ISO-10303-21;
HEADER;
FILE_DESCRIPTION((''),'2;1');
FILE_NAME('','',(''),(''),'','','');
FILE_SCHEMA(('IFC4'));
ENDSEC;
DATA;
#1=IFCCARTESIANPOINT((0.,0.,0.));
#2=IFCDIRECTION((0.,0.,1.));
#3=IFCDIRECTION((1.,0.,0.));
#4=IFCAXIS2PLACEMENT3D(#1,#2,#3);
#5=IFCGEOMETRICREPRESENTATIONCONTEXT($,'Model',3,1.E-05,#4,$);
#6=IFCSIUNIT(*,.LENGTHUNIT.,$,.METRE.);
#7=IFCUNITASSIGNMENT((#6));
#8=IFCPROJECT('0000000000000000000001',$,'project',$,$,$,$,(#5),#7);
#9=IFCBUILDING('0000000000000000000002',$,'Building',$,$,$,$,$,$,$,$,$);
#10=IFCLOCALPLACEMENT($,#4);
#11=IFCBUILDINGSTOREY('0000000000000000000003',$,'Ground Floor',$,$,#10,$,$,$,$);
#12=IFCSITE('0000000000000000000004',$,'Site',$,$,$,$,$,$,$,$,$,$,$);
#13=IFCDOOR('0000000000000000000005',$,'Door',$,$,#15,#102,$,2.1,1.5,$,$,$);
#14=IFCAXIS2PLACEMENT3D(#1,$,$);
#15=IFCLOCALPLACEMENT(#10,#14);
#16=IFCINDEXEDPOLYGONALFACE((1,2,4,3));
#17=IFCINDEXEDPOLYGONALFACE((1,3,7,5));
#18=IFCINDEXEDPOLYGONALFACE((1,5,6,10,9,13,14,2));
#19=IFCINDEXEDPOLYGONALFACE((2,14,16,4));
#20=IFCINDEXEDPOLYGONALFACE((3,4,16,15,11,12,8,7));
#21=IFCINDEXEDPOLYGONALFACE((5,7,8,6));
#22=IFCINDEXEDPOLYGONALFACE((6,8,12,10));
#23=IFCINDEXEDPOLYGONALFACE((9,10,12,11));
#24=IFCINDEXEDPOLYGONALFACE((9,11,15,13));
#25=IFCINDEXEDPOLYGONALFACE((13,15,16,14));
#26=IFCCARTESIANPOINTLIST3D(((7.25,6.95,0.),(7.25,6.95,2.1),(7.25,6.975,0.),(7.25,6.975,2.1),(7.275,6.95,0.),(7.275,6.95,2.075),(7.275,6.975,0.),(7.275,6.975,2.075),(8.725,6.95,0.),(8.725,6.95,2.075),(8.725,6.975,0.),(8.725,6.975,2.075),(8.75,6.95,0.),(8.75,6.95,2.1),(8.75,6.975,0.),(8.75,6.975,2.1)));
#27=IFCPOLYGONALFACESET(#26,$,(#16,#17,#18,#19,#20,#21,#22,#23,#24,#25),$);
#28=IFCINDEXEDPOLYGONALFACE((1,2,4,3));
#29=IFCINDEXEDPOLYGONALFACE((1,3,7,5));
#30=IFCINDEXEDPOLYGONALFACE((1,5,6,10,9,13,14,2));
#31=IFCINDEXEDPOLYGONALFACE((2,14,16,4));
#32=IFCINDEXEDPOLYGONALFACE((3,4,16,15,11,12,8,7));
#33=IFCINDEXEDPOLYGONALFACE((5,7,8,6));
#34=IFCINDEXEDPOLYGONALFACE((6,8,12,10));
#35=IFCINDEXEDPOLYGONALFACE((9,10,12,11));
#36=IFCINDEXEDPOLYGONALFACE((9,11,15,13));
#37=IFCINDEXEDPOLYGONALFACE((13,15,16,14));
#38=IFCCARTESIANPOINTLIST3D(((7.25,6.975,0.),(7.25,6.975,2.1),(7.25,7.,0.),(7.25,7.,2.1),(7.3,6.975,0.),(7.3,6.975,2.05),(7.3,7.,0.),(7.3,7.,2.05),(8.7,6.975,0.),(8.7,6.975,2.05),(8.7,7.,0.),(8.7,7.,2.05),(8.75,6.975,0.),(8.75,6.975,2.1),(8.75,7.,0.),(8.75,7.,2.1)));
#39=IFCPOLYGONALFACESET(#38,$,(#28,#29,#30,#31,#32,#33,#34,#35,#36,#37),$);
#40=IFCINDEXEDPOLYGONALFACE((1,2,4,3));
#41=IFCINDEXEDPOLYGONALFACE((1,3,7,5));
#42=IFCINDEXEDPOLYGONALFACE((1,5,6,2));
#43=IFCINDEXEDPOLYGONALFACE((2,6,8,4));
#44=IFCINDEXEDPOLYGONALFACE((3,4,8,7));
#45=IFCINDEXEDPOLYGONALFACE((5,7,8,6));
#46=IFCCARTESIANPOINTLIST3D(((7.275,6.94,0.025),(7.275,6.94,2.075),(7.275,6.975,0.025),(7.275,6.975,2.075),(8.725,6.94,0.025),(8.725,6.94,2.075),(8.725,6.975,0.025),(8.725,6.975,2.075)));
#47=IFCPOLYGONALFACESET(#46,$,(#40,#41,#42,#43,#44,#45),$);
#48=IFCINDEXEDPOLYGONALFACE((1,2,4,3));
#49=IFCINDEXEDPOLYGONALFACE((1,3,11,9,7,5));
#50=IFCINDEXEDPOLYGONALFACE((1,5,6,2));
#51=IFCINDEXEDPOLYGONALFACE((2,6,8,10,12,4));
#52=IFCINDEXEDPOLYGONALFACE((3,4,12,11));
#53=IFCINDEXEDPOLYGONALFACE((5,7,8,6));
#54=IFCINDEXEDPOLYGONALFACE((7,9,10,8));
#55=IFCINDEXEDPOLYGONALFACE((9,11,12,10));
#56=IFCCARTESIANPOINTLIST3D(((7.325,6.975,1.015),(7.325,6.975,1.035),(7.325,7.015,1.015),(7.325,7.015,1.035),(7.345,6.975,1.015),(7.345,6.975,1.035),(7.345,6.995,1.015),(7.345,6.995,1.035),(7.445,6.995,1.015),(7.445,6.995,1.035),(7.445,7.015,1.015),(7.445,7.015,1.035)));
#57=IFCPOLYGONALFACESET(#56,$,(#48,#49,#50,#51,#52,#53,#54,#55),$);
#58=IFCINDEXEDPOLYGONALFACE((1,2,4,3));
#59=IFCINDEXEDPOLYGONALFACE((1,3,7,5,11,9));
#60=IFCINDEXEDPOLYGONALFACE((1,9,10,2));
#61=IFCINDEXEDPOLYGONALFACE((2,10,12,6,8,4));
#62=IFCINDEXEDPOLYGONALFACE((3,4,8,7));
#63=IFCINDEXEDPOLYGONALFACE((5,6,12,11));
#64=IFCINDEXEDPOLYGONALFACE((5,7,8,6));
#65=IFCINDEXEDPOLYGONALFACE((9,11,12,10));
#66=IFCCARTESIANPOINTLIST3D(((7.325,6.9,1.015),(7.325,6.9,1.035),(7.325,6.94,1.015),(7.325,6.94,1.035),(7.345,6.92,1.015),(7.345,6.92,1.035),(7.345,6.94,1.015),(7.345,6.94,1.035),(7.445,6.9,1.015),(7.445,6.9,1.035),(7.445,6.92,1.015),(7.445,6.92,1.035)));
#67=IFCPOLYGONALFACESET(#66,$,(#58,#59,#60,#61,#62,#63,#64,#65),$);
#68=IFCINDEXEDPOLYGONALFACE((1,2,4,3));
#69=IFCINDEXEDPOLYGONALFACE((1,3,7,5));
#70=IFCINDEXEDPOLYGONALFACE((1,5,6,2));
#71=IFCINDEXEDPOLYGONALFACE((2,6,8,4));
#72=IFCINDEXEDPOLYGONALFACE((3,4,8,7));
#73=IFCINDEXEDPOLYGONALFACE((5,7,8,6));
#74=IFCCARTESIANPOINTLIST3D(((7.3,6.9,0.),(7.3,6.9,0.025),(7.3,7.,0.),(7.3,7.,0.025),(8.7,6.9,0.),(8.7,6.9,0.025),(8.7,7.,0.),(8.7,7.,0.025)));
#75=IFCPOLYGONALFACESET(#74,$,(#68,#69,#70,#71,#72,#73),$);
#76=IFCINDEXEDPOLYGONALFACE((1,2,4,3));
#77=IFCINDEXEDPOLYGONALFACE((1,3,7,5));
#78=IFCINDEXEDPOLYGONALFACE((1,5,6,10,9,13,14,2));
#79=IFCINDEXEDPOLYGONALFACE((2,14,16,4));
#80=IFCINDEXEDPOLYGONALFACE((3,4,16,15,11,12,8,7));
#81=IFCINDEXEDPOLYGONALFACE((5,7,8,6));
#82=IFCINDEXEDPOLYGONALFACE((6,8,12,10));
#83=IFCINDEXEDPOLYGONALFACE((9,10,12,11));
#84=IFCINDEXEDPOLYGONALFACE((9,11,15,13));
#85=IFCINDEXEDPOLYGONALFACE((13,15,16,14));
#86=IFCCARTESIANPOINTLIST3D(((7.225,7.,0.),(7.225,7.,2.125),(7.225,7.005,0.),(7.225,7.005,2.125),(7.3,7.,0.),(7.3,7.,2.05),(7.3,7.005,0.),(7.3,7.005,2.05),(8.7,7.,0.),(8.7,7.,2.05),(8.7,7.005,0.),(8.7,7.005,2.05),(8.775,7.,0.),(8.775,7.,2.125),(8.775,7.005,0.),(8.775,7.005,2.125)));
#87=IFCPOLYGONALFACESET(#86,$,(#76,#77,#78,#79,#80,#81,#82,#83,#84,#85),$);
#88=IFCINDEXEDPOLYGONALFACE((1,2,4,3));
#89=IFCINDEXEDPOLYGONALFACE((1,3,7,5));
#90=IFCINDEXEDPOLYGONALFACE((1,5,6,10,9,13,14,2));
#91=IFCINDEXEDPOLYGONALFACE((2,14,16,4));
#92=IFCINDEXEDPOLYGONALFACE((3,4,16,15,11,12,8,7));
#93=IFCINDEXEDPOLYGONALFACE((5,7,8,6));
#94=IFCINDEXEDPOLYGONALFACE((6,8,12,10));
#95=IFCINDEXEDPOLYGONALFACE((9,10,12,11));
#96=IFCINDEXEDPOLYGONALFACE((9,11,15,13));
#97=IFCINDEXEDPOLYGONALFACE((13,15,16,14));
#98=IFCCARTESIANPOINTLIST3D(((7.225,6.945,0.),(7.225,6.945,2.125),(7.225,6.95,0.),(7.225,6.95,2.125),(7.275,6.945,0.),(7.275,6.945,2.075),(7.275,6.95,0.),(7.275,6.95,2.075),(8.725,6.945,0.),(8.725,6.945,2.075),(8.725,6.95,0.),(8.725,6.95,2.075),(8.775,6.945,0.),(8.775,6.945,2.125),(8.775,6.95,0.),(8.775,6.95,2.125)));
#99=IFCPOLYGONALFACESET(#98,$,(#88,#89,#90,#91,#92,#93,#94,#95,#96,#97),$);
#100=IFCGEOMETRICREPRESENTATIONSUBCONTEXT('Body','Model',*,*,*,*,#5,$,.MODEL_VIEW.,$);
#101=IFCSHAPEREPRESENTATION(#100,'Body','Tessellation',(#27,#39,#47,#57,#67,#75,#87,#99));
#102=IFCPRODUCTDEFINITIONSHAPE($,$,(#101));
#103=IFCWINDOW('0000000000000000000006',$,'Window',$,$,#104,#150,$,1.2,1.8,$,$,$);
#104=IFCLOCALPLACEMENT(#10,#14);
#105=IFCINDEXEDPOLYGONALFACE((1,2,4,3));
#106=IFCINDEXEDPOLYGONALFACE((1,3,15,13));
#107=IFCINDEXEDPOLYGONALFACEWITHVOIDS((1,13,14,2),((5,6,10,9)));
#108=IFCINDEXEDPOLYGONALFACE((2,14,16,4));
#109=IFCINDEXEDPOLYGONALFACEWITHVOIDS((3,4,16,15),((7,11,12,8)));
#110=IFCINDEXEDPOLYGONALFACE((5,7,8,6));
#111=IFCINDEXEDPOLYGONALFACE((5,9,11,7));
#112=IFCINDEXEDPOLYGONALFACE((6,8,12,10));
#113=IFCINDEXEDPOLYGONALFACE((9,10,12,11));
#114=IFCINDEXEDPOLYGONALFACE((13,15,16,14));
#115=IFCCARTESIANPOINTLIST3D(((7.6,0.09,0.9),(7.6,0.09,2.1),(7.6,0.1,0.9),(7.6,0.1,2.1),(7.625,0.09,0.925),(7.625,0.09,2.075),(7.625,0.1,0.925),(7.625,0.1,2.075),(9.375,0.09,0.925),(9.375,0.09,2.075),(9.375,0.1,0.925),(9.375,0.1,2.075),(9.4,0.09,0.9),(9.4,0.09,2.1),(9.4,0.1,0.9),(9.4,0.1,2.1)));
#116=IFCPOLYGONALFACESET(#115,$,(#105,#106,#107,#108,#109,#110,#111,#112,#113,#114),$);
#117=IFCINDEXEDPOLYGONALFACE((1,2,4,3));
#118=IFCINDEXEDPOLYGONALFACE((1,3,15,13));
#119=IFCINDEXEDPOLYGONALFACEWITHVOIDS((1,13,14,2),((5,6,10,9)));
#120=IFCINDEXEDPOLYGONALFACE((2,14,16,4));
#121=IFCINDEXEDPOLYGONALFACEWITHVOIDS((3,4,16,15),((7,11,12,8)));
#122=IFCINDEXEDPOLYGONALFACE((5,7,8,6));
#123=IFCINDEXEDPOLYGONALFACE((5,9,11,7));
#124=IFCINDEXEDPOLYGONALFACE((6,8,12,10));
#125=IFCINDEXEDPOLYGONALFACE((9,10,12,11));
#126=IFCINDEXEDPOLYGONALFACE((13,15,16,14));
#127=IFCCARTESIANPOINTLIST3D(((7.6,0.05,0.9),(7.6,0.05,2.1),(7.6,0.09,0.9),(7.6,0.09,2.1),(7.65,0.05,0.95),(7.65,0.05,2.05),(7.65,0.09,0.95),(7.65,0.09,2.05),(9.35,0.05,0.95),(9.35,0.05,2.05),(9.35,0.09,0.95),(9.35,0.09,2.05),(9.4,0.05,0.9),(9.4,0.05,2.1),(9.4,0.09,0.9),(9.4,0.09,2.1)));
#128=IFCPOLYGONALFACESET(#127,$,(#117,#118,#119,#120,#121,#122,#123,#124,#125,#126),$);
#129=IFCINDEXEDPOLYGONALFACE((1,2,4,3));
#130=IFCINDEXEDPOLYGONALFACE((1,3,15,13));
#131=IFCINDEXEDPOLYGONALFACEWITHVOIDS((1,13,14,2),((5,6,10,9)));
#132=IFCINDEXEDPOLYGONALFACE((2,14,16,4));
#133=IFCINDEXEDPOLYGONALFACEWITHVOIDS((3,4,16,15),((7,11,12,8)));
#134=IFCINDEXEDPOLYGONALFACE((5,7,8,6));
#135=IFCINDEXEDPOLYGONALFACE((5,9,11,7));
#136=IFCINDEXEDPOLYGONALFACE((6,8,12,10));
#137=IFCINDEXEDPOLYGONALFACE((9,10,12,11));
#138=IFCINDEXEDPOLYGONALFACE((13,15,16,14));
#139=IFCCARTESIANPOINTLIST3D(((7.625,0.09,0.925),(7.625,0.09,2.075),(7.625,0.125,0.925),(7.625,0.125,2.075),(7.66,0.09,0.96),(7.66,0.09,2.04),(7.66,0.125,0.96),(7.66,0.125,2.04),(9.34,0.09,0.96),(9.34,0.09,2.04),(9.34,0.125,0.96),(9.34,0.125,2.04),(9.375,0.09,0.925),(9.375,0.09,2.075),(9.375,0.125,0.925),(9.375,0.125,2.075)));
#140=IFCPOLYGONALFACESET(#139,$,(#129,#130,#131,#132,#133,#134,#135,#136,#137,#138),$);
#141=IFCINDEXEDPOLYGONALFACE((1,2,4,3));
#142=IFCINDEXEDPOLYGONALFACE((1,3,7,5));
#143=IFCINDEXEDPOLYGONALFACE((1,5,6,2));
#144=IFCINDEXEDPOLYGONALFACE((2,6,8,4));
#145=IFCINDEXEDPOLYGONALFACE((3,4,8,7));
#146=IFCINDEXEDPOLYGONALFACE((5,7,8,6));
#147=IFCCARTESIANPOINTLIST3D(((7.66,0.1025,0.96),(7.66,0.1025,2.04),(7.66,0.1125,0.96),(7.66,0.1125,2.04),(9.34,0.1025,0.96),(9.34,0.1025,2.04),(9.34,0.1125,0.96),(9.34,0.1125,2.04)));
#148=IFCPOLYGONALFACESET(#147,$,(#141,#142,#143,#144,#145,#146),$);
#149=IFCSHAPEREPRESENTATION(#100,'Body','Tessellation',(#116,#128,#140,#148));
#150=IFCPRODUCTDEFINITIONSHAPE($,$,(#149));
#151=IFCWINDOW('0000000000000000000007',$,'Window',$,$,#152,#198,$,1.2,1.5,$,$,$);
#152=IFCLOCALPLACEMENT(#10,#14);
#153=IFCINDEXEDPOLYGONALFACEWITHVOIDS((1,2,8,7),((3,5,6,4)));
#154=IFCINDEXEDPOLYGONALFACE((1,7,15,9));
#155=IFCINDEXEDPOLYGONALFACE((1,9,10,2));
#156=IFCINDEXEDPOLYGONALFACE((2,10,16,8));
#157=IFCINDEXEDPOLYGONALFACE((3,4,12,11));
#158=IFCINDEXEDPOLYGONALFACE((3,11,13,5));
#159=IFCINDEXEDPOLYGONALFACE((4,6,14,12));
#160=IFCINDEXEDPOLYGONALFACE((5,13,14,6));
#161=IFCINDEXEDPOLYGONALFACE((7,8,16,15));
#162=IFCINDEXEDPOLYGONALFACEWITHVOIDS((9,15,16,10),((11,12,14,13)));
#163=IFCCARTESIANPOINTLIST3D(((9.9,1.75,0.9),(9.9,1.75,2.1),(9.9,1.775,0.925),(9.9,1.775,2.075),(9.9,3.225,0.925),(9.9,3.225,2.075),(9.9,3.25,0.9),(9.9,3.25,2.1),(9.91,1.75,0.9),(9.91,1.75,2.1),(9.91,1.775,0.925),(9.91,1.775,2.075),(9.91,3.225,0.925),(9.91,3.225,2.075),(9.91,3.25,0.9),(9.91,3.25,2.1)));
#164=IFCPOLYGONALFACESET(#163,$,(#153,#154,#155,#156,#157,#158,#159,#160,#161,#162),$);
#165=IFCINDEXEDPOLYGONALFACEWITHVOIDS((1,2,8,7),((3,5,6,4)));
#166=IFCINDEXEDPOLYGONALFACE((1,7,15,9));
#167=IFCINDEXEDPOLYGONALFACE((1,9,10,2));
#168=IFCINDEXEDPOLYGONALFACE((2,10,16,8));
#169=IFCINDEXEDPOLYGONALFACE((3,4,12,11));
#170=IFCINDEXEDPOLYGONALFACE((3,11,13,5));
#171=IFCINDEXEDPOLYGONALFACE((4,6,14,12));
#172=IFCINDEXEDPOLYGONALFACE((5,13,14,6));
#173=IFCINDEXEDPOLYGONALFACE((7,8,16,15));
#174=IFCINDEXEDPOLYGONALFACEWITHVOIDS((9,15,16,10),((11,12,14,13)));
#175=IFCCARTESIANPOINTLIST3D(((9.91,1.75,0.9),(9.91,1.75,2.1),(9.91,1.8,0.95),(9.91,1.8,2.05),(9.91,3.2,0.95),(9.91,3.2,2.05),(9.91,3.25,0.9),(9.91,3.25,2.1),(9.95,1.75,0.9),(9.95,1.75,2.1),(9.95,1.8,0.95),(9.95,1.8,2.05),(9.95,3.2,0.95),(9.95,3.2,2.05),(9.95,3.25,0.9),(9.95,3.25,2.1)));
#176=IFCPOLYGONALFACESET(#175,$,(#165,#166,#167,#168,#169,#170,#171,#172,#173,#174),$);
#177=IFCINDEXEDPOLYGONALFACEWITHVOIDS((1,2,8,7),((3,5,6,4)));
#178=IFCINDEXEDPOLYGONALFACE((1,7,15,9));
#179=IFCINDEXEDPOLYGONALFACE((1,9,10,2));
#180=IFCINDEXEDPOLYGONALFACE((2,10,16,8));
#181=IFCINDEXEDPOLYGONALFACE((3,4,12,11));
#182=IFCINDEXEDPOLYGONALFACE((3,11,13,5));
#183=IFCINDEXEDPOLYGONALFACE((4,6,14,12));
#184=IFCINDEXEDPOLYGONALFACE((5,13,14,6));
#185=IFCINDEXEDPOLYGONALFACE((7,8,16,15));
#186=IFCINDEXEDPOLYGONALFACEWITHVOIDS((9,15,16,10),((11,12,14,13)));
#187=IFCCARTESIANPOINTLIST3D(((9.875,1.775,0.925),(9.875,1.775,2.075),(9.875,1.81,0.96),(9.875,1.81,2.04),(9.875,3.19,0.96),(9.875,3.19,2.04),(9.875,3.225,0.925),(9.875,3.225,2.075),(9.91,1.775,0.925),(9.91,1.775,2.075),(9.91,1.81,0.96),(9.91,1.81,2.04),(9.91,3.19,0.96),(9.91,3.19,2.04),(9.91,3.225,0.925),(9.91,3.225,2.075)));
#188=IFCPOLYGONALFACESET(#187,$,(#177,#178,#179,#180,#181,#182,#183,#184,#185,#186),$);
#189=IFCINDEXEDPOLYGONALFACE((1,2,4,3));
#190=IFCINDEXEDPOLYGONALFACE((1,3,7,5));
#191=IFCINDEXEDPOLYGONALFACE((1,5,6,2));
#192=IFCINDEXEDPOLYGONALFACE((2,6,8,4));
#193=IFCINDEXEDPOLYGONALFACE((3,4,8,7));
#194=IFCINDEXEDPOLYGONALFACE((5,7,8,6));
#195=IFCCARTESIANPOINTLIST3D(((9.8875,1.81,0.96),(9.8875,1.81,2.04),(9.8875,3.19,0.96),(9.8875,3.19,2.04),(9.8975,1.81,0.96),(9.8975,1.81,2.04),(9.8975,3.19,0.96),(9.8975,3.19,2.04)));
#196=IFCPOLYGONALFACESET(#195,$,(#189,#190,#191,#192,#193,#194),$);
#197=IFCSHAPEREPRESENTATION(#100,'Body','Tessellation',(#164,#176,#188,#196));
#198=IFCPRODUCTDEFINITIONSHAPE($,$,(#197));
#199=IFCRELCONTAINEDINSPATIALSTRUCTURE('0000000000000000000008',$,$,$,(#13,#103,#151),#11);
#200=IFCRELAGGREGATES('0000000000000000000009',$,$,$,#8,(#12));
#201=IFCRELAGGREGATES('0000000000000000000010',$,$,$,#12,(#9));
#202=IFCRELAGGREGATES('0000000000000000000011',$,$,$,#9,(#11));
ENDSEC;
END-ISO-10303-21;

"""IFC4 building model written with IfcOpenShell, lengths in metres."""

from ifc_helpers import new_model, si_unit, frame, origin_with_axes, place, context, subcontext, project, spatial, line, indexed_curve, outline, extrude, element, save


model = new_model("IFC4")

# Units and contexts
model_context = context("Model", 3, precision=1e-05, world=origin_with_axes())
body_context = subcontext(model_context, "Body", "Model", "MODEL_VIEW")
ifc_project = project(units=[si_unit("LENGTHUNIT", "METRE")], contexts=[model_context])

# Site, building, storey
site = spatial("IfcSite", under=ifc_project, Name="Site")
building = spatial("IfcBuilding", under=site, Name="Building")
storey_placement = place(None, origin_with_axes())
storey = spatial("IfcBuildingStorey", under=building, at=storey_placement, Name="Ground Floor")

# Door
door_1_placement = place(storey_placement, frame((8.75, 7.0, 0.0), z_axis=(0.0, 0.0, 1.0), x_axis=(-1.0, 0.0, 0.0)))
element("IfcDoor", 1, at=door_1_placement, inside=storey, Name="Door", OverallHeight=2.1, OverallWidth=1.5, context=body_context, shape_type="SweptSolid", body=[
    extrude(outline(indexed_curve([(0.0, 0.0), (0.0, 2.1), (1.5, 2.1), (1.5, 0.0), (1.475, 0.0), (1.475, 2.075), (0.025, 2.075), (0.025, 0.0)], segments=[line(1, 2, 3, 4, 5, 6, 7, 8, 1)])), frame((0.0, 0.025, 0.0), z_axis=(0.0, -1.0, 0.0), x_axis=(1.0, 0.0, 0.0)), (0.0, 0.0, -1.0), 0.025),
    extrude(outline(indexed_curve([(0.0, 0.0), (0.0, 2.1), (1.5, 2.1), (1.5, 0.0), (1.45, 0.0), (1.45, 2.05), (0.05, 2.05), (0.05, 0.0)], segments=[line(1, 2, 3, 4, 5, 6, 7, 8, 1)])), frame((0.0, 0.0, 0.0), z_axis=(0.0, -1.0, 0.0), x_axis=(1.0, 0.0, 0.0)), (0.0, 0.0, -1.0), 0.025),
    extrude(outline(indexed_curve([(0.0, 0.0), (1.45, 0.0), (1.45, 0.035), (0.0, 0.035)], segments=[line(1, 2, 3, 4, 1)])), frame((0.025, 0.025, 0.025), z_axis=(0.0, 0.0, 1.0), x_axis=(1.0, 0.0, 0.0)), (0.0, 0.0, 1.0), 2.05),
    extrude(outline(indexed_curve([(0.0, 0.0), (0.0, -0.04), (-0.12, -0.04), (-0.12, -0.02), (-0.02, -0.02), (-0.02, 0.0)], segments=[line(1, 2, 3, 4, 5, 6, 1)])), frame((1.425, 0.025, 1.015), z_axis=(0.0, 0.0, 1.0), x_axis=(1.0, 0.0, 0.0)), (0.0, 0.0, 1.0), 0.02),
    extrude(outline(indexed_curve([(0.0, 0.0), (0.0, 0.04), (-0.12, 0.04), (-0.12, 0.02), (-0.02, 0.02), (-0.02, 0.0)], segments=[line(1, 2, 3, 4, 5, 6, 1)])), frame((1.425, 0.06, 1.015), z_axis=(0.0, 0.0, 1.0), x_axis=(1.0, 0.0, 0.0)), (0.0, 0.0, 1.0), 0.02),
    extrude(outline(indexed_curve([(0.0, 0.0), (1.4, 0.0), (1.4, 0.1), (0.0, 0.1)], segments=[line(1, 2, 3, 4, 1)])), frame((0.05, 0.0, 0.0), z_axis=(0.0, 0.0, 1.0), x_axis=(1.0, 0.0, 0.0)), (0.0, 0.0, 1.0), 0.025),
    extrude(outline(indexed_curve([(0.0, 0.0), (0.0, 2.125), (1.55, 2.125), (1.55, 0.0), (1.475, 0.0), (1.475, 2.05), (0.075, 2.05), (0.075, 0.0)], segments=[line(1, 2, 3, 4, 5, 6, 7, 8, 1)])), frame((-0.025, -0.005, 0.0), z_axis=(0.0, -1.0, 0.0), x_axis=(1.0, 0.0, 0.0)), (0.0, 0.0, -1.0), 0.005),
    extrude(outline(indexed_curve([(0.0, 0.0), (0.0, 2.125), (1.55, 2.125), (1.55, 0.0), (1.5, 0.0), (1.5, 2.075), (0.05, 2.075), (0.05, 0.0)], segments=[line(1, 2, 3, 4, 5, 6, 7, 8, 1)])), frame((-0.025, 0.05, 0.0), z_axis=(0.0, -1.0, 0.0), x_axis=(1.0, 0.0, 0.0)), (0.0, 0.0, -1.0), 0.005),
])

# Windows
window_1_placement = place(storey_placement, frame((7.6, 0.0, 0.9), z_axis=(0.0, 0.0, 1.0), x_axis=(1.0, 0.0, 0.0)))
element("IfcWindow", 2, at=window_1_placement, inside=storey, Name="Window", OverallHeight=1.2, OverallWidth=1.8, context=body_context, shape_type="SweptSolid", body=[
    extrude(outline(indexed_curve([(0.0, 0.0), (1.8, 0.0), (1.8, 1.2), (0.0, 1.2)], segments=[line(1, 2, 3, 4, 1)]), holes=[indexed_curve([(0.025, 0.025), (1.775, 0.025), (1.775, 1.175), (0.025, 1.175)], segments=[line(1, 2, 3, 4, 1)])]), frame((0.0, 0.09, 0.0), z_axis=(0.0, -1.0, 0.0), x_axis=(1.0, 0.0, 0.0)), (0.0, 0.0, -1.0), 0.01),
    extrude(outline(indexed_curve([(0.0, 0.0), (1.8, 0.0), (1.8, 1.2), (0.0, 1.2)], segments=[line(1, 2, 3, 4, 1)]), holes=[indexed_curve([(0.05, 0.05), (1.75, 0.05), (1.75, 1.15), (0.05, 1.15)], segments=[line(1, 2, 3, 4, 1)])]), frame((0.0, 0.05, 0.0), z_axis=(0.0, -1.0, 0.0), x_axis=(1.0, 0.0, 0.0)), (0.0, 0.0, -1.0), 0.04),
    extrude(outline(indexed_curve([(0.0, 0.0), (1.75, 0.0), (1.75, 1.15), (0.0, 1.15)], segments=[line(1, 2, 3, 4, 1)]), holes=[indexed_curve([(0.035, 0.035), (1.715, 0.035), (1.715, 1.115), (0.035, 1.115)], segments=[line(1, 2, 3, 4, 1)])]), frame((0.025, 0.09, 0.025), z_axis=(0.0, -1.0, 0.0), x_axis=(1.0, 0.0, 0.0)), (0.0, 0.0, -1.0), 0.035),
    extrude(outline(indexed_curve([(0.035, 0.035), (1.715, 0.035), (1.715, 1.115), (0.035, 1.115)], segments=[line(1, 2, 3, 4, 1)])), frame((0.025, 0.1025, 0.025), z_axis=(0.0, -1.0, 0.0), x_axis=(1.0, 0.0, 0.0)), (0.0, 0.0, -1.0), 0.01),
])
window_2_placement = place(storey_placement, frame((10.0, 1.75, 0.9), z_axis=(0.0, 0.0, 1.0), x_axis=(0.0, 1.0, 0.0)))
element("IfcWindow", 3, at=window_2_placement, inside=storey, Name="Window", OverallHeight=1.2, OverallWidth=1.5, context=body_context, shape_type="SweptSolid", body=[
    extrude(outline(indexed_curve([(0.0, 0.0), (1.5, 0.0), (1.5, 1.2), (0.0, 1.2)], segments=[line(1, 2, 3, 4, 1)]), holes=[indexed_curve([(0.025, 0.025), (1.475, 0.025), (1.475, 1.175), (0.025, 1.175)], segments=[line(1, 2, 3, 4, 1)])]), frame((0.0, 0.09, 0.0), z_axis=(0.0, -1.0, 0.0), x_axis=(1.0, 0.0, 0.0)), (0.0, 0.0, -1.0), 0.01),
    extrude(outline(indexed_curve([(0.0, 0.0), (1.5, 0.0), (1.5, 1.2), (0.0, 1.2)], segments=[line(1, 2, 3, 4, 1)]), holes=[indexed_curve([(0.05, 0.05), (1.45, 0.05), (1.45, 1.15), (0.05, 1.15)], segments=[line(1, 2, 3, 4, 1)])]), frame((0.0, 0.05, 0.0), z_axis=(0.0, -1.0, 0.0), x_axis=(1.0, 0.0, 0.0)), (0.0, 0.0, -1.0), 0.04),
    extrude(outline(indexed_curve([(0.0, 0.0), (1.45, 0.0), (1.45, 1.15), (0.0, 1.15)], segments=[line(1, 2, 3, 4, 1)]), holes=[indexed_curve([(0.035, 0.035), (1.415, 0.035), (1.415, 1.115), (0.035, 1.115)], segments=[line(1, 2, 3, 4, 1)])]), frame((0.025, 0.09, 0.025), z_axis=(0.0, -1.0, 0.0), x_axis=(1.0, 0.0, 0.0)), (0.0, 0.0, -1.0), 0.035),
    extrude(outline(indexed_curve([(0.035, 0.035), (1.415, 0.035), (1.415, 1.115), (0.035, 1.115)], segments=[line(1, 2, 3, 4, 1)])), frame((0.025, 0.1025, 0.025), z_axis=(0.0, -1.0, 0.0), x_axis=(1.0, 0.0, 0.0)), (0.0, 0.0, -1.0), 0.01),
])

save(model, "model.ifc")
